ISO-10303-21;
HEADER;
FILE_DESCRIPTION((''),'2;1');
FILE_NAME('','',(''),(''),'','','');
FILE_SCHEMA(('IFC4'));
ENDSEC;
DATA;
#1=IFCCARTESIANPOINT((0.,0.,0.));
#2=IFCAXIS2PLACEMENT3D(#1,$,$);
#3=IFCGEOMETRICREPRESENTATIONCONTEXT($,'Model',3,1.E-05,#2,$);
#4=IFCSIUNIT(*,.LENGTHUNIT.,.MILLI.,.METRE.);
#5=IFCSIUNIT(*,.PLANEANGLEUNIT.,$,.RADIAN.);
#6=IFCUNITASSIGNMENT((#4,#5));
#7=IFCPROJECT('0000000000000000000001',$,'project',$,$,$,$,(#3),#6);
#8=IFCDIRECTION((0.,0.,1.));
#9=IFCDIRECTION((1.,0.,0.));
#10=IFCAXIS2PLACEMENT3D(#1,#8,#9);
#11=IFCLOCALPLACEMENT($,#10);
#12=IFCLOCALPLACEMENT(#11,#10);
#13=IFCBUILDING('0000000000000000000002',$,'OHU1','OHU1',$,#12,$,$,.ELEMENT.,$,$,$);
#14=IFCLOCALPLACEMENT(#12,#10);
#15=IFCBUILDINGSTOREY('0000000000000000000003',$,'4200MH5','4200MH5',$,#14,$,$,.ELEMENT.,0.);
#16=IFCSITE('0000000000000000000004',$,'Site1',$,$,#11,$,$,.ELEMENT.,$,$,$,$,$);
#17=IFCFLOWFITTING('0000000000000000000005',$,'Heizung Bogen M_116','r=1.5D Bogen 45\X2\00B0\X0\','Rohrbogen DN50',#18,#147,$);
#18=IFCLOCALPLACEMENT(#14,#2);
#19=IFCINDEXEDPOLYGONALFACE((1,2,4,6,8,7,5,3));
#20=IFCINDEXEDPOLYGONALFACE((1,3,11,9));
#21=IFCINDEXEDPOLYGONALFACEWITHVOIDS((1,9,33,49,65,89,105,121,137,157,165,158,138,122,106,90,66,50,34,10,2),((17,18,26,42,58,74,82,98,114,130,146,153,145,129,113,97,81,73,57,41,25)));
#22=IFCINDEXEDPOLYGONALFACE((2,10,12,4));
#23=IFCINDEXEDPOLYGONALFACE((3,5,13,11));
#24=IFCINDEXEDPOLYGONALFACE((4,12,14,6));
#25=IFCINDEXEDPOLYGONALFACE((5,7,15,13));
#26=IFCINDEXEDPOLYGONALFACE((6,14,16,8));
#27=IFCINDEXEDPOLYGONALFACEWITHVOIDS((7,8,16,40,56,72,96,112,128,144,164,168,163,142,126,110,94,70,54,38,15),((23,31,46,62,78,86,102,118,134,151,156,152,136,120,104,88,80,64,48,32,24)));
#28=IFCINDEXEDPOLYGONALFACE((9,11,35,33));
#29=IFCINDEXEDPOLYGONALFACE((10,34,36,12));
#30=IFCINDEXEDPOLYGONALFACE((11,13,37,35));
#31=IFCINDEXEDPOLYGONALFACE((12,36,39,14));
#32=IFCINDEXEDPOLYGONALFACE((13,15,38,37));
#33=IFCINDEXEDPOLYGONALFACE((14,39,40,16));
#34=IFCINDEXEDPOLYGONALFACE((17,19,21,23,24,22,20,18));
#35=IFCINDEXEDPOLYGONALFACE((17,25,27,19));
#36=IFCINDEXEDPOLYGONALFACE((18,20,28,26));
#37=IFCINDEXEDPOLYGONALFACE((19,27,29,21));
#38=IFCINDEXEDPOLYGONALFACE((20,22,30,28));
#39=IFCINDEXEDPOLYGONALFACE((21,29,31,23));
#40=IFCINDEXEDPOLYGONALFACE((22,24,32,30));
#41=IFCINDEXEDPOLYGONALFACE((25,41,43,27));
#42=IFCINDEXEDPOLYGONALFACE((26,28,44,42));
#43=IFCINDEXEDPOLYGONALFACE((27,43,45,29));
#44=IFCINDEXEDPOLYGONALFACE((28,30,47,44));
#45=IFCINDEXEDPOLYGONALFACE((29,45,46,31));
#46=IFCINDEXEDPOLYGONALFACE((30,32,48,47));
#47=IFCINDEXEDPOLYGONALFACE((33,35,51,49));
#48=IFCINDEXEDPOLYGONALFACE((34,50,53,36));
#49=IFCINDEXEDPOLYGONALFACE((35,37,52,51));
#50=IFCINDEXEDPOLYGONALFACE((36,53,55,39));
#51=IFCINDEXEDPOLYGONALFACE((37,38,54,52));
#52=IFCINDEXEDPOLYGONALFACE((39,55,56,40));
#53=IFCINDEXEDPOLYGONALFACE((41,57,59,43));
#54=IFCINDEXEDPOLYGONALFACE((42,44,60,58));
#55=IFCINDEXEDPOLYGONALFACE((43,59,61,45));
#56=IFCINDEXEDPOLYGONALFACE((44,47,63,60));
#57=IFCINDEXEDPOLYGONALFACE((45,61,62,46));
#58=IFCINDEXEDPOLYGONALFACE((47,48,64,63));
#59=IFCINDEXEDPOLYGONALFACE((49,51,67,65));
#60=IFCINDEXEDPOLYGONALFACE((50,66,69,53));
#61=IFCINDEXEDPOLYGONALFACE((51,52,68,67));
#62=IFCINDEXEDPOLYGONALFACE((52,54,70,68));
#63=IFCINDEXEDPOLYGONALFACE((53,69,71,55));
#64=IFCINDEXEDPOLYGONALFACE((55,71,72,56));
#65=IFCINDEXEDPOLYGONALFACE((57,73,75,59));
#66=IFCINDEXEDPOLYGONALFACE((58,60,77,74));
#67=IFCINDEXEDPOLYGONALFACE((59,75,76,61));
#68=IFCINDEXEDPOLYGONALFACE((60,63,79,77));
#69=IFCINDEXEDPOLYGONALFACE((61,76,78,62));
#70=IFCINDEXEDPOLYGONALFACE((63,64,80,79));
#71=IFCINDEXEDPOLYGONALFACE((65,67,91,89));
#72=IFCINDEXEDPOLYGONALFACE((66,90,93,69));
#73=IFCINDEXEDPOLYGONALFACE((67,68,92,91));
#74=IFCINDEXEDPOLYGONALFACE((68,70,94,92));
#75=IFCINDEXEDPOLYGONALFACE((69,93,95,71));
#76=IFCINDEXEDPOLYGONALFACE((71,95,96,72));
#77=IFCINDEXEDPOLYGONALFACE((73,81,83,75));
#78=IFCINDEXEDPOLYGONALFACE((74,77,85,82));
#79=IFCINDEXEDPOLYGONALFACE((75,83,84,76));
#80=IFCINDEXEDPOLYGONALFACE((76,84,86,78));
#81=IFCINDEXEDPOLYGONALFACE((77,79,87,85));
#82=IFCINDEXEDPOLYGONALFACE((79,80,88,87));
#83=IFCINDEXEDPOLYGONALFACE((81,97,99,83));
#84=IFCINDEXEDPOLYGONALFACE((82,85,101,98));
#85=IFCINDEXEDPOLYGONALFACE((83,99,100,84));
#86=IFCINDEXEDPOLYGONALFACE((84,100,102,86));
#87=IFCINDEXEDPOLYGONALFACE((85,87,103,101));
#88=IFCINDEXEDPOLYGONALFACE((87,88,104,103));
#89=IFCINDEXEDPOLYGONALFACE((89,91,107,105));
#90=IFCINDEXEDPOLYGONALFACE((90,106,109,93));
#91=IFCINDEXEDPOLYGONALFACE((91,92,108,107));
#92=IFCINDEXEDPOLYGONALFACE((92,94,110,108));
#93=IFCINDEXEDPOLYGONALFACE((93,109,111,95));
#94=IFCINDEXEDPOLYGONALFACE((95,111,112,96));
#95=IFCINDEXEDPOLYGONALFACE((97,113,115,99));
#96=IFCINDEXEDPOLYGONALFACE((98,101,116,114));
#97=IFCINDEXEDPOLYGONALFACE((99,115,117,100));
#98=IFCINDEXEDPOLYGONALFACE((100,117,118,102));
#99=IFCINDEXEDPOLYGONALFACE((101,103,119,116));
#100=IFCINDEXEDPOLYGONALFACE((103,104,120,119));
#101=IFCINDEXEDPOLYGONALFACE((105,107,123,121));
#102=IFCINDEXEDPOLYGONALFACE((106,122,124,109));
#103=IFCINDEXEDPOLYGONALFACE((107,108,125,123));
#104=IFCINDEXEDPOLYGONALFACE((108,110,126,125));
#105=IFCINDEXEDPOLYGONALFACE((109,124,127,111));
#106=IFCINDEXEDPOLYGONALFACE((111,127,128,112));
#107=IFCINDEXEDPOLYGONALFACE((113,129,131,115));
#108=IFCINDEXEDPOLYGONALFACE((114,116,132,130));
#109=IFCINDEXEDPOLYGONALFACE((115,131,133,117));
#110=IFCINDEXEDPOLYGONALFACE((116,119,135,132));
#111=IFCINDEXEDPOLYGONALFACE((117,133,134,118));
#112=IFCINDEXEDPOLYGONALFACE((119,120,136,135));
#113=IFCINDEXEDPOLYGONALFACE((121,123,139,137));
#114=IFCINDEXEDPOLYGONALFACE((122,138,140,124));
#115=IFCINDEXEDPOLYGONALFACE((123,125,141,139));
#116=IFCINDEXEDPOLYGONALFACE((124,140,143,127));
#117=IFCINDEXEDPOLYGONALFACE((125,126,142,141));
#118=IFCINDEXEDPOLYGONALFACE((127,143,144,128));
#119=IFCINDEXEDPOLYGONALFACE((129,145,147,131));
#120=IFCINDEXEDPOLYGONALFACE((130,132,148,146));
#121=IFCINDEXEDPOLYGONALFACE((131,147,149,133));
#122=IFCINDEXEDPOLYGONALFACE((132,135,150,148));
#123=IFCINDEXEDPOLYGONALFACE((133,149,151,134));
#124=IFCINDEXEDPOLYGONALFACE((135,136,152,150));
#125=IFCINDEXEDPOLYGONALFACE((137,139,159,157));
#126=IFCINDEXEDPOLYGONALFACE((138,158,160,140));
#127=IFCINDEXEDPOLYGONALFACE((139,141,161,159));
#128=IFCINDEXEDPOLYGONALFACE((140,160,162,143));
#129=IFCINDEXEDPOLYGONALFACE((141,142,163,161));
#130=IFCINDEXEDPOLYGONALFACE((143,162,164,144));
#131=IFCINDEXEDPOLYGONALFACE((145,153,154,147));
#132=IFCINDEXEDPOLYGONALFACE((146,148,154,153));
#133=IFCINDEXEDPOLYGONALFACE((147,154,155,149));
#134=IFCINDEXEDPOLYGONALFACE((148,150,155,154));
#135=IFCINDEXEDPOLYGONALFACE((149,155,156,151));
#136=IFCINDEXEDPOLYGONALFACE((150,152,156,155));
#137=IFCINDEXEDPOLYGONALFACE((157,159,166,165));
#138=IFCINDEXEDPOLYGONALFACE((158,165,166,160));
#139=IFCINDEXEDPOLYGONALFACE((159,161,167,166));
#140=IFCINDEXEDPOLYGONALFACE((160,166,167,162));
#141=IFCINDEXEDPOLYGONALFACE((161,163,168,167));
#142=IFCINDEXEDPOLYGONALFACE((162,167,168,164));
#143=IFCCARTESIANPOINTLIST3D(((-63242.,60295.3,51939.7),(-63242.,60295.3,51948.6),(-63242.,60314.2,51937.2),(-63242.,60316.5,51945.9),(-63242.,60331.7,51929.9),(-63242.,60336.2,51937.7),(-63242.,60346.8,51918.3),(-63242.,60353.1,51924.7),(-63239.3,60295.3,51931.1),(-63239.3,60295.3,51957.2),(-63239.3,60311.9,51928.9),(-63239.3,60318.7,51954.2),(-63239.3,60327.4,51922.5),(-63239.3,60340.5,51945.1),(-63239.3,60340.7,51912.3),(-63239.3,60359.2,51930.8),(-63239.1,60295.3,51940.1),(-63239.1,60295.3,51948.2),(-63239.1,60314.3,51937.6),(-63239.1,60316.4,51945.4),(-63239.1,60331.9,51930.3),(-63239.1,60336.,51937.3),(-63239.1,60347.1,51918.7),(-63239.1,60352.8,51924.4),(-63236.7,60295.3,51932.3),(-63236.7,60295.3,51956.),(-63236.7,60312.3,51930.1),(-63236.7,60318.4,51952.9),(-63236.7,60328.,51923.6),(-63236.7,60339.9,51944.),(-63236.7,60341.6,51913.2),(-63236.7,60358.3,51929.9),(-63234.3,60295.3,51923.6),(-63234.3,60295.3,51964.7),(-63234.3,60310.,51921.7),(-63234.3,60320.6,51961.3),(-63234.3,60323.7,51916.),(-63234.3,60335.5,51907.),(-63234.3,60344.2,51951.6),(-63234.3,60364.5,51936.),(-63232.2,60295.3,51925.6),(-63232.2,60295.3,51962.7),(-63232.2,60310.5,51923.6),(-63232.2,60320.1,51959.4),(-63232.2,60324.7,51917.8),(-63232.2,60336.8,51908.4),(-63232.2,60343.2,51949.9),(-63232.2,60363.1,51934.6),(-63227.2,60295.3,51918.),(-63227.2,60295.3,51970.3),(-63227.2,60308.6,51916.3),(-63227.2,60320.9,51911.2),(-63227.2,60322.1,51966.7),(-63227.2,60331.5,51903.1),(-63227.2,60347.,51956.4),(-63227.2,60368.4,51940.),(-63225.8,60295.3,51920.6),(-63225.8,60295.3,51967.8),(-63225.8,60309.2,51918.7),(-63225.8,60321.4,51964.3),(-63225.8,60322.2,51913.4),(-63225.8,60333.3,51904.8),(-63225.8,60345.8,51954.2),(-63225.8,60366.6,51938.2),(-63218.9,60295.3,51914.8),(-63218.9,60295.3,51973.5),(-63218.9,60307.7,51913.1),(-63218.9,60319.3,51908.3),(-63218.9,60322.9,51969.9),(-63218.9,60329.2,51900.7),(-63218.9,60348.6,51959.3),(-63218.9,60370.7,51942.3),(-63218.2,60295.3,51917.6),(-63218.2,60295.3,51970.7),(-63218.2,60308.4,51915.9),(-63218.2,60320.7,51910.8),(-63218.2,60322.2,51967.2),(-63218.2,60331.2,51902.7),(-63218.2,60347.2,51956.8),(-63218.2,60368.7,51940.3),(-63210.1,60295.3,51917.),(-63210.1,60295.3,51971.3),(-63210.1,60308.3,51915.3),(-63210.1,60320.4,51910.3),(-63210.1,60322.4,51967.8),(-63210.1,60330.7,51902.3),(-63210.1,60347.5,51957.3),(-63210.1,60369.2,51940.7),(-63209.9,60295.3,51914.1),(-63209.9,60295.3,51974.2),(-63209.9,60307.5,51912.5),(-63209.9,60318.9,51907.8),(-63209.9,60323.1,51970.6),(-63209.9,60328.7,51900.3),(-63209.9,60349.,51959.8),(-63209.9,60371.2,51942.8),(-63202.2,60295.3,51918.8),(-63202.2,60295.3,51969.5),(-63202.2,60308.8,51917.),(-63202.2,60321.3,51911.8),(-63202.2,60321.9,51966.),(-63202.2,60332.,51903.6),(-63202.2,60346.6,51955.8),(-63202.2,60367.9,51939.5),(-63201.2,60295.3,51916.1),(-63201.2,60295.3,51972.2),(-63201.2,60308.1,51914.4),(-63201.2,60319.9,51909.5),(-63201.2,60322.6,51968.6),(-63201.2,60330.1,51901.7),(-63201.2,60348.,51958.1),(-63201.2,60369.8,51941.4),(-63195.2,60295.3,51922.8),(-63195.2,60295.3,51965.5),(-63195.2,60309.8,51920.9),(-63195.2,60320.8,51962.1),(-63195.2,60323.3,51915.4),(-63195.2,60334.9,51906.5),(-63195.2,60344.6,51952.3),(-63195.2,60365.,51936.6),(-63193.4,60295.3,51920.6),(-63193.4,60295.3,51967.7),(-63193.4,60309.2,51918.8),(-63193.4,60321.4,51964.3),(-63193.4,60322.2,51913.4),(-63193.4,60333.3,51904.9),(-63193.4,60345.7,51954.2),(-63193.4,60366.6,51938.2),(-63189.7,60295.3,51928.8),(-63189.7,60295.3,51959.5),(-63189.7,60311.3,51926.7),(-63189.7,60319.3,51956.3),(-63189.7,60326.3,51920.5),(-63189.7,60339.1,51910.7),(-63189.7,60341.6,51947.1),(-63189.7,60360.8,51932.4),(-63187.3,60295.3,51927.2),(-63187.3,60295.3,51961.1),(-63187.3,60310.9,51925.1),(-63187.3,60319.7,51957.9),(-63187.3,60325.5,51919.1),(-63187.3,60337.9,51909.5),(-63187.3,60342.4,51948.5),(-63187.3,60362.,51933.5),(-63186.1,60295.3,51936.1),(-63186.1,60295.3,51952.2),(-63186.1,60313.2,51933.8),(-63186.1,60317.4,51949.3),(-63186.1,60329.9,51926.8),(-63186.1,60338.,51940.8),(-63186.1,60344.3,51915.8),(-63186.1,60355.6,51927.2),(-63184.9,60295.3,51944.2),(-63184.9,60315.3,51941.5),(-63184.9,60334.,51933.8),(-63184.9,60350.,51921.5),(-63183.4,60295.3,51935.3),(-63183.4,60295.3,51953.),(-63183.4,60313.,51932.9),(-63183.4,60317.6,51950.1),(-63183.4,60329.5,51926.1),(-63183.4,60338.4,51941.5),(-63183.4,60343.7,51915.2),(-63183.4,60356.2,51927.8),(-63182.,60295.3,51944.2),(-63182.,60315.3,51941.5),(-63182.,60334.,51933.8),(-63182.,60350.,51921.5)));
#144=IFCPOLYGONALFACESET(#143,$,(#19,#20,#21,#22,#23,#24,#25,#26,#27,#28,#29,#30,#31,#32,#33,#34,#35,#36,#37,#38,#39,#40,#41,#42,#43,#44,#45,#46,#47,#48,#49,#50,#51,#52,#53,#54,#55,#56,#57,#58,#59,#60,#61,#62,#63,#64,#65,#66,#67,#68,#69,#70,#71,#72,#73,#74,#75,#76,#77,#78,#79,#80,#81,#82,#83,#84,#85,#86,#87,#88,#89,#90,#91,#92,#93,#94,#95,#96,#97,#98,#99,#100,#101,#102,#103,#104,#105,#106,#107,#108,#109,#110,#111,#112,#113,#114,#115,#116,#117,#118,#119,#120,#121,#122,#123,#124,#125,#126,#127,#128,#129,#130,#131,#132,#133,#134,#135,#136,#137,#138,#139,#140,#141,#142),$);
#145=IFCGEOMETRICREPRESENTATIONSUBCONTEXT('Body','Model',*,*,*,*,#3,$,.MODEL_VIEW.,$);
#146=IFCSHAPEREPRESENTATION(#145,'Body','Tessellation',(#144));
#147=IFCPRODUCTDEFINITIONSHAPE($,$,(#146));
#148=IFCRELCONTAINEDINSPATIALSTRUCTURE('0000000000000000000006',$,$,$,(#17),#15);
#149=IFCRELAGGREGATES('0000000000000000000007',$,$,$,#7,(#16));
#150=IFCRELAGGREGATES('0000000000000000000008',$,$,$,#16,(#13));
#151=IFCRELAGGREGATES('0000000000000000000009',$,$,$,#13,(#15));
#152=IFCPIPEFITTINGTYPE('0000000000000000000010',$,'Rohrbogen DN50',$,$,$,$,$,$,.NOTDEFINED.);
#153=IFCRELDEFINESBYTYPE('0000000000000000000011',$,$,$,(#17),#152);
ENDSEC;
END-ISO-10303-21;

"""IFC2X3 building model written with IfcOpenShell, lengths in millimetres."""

from ifc_helpers import new_model, entity, si_unit, frame, origin, origin_with_axes, place, context, subcontext, project, spatial, type_object, element, save


model = new_model("IFC2X3")

# Units and contexts
model_context = context("Model", 3, precision=1e-05, world=origin())
body_context = subcontext(model_context, "Body", "Model", "MODEL_VIEW")
ifc_project = project(units=[si_unit("LENGTHUNIT", "METRE", prefix="MILLI"), si_unit("PLANEANGLEUNIT", "RADIAN")], contexts=[model_context])

# Site, building, storey
site_placement = place(None, origin_with_axes())
site = spatial("IfcSite", under=ifc_project, at=site_placement, Name="Site1", CompositionType="ELEMENT")
building_placement = place(site_placement, origin_with_axes())
building = spatial("IfcBuilding", under=site, at=building_placement, Name="OHU1", Description="OHU1", CompositionType="ELEMENT")
storey_placement = place(building_placement, origin_with_axes())
storey = spatial("IfcBuildingStorey", under=building, at=storey_placement, Name="4200MH5", Description="4200MH5", CompositionType="ELEMENT", Elevation=0.0)

# Flow fitting
pipe_fitting_type_1 = type_object("IfcPipeFittingType", Name="Rohrbogen DN50", PredefinedType="NOTDEFINED")
flow_fitting_1_placement = place(storey_placement, frame((-63212.2, 60348.2, 51944.2), z_axis=(0.0, 0.0, 1.0), x_axis=(1.0, 0.0, 0.0)))
element("IfcFlowFitting", 1, at=flow_fitting_1_placement, inside=storey, type_object=pipe_fitting_type_1, Name="Heizung Bogen M_116", Description="r=1.5D Bogen 45°", ObjectType="Rohrbogen DN50", context=body_context, shape_type="SweptSolid", body=[
    entity("IfcRevolvedAreaSolid", entity("IfcCircleHollowProfileDef", "AREA", None, entity("IfcAxis2Placement2D", entity("IfcCartesianPoint", [0.0, 0.0]), entity("IfcDirection", [1.0, 0.0])), 30.1, 2.9), entity("IfcAxis2Placement3D", entity("IfcCartesianPoint", [0.0, -52.9, 0.0]), entity("IfcDirection", [0.000003, 1.0, 0.0]), entity("IfcDirection", [1.0, -0.000003, 0.0])), entity("IfcAxis1Placement", entity("IfcCartesianPoint", [0.0, 77.3, 0.0]), entity("IfcDirection", [-1.0, 0.0, 0.0])), 0.785398),
])

save(model, "model.ifc")
